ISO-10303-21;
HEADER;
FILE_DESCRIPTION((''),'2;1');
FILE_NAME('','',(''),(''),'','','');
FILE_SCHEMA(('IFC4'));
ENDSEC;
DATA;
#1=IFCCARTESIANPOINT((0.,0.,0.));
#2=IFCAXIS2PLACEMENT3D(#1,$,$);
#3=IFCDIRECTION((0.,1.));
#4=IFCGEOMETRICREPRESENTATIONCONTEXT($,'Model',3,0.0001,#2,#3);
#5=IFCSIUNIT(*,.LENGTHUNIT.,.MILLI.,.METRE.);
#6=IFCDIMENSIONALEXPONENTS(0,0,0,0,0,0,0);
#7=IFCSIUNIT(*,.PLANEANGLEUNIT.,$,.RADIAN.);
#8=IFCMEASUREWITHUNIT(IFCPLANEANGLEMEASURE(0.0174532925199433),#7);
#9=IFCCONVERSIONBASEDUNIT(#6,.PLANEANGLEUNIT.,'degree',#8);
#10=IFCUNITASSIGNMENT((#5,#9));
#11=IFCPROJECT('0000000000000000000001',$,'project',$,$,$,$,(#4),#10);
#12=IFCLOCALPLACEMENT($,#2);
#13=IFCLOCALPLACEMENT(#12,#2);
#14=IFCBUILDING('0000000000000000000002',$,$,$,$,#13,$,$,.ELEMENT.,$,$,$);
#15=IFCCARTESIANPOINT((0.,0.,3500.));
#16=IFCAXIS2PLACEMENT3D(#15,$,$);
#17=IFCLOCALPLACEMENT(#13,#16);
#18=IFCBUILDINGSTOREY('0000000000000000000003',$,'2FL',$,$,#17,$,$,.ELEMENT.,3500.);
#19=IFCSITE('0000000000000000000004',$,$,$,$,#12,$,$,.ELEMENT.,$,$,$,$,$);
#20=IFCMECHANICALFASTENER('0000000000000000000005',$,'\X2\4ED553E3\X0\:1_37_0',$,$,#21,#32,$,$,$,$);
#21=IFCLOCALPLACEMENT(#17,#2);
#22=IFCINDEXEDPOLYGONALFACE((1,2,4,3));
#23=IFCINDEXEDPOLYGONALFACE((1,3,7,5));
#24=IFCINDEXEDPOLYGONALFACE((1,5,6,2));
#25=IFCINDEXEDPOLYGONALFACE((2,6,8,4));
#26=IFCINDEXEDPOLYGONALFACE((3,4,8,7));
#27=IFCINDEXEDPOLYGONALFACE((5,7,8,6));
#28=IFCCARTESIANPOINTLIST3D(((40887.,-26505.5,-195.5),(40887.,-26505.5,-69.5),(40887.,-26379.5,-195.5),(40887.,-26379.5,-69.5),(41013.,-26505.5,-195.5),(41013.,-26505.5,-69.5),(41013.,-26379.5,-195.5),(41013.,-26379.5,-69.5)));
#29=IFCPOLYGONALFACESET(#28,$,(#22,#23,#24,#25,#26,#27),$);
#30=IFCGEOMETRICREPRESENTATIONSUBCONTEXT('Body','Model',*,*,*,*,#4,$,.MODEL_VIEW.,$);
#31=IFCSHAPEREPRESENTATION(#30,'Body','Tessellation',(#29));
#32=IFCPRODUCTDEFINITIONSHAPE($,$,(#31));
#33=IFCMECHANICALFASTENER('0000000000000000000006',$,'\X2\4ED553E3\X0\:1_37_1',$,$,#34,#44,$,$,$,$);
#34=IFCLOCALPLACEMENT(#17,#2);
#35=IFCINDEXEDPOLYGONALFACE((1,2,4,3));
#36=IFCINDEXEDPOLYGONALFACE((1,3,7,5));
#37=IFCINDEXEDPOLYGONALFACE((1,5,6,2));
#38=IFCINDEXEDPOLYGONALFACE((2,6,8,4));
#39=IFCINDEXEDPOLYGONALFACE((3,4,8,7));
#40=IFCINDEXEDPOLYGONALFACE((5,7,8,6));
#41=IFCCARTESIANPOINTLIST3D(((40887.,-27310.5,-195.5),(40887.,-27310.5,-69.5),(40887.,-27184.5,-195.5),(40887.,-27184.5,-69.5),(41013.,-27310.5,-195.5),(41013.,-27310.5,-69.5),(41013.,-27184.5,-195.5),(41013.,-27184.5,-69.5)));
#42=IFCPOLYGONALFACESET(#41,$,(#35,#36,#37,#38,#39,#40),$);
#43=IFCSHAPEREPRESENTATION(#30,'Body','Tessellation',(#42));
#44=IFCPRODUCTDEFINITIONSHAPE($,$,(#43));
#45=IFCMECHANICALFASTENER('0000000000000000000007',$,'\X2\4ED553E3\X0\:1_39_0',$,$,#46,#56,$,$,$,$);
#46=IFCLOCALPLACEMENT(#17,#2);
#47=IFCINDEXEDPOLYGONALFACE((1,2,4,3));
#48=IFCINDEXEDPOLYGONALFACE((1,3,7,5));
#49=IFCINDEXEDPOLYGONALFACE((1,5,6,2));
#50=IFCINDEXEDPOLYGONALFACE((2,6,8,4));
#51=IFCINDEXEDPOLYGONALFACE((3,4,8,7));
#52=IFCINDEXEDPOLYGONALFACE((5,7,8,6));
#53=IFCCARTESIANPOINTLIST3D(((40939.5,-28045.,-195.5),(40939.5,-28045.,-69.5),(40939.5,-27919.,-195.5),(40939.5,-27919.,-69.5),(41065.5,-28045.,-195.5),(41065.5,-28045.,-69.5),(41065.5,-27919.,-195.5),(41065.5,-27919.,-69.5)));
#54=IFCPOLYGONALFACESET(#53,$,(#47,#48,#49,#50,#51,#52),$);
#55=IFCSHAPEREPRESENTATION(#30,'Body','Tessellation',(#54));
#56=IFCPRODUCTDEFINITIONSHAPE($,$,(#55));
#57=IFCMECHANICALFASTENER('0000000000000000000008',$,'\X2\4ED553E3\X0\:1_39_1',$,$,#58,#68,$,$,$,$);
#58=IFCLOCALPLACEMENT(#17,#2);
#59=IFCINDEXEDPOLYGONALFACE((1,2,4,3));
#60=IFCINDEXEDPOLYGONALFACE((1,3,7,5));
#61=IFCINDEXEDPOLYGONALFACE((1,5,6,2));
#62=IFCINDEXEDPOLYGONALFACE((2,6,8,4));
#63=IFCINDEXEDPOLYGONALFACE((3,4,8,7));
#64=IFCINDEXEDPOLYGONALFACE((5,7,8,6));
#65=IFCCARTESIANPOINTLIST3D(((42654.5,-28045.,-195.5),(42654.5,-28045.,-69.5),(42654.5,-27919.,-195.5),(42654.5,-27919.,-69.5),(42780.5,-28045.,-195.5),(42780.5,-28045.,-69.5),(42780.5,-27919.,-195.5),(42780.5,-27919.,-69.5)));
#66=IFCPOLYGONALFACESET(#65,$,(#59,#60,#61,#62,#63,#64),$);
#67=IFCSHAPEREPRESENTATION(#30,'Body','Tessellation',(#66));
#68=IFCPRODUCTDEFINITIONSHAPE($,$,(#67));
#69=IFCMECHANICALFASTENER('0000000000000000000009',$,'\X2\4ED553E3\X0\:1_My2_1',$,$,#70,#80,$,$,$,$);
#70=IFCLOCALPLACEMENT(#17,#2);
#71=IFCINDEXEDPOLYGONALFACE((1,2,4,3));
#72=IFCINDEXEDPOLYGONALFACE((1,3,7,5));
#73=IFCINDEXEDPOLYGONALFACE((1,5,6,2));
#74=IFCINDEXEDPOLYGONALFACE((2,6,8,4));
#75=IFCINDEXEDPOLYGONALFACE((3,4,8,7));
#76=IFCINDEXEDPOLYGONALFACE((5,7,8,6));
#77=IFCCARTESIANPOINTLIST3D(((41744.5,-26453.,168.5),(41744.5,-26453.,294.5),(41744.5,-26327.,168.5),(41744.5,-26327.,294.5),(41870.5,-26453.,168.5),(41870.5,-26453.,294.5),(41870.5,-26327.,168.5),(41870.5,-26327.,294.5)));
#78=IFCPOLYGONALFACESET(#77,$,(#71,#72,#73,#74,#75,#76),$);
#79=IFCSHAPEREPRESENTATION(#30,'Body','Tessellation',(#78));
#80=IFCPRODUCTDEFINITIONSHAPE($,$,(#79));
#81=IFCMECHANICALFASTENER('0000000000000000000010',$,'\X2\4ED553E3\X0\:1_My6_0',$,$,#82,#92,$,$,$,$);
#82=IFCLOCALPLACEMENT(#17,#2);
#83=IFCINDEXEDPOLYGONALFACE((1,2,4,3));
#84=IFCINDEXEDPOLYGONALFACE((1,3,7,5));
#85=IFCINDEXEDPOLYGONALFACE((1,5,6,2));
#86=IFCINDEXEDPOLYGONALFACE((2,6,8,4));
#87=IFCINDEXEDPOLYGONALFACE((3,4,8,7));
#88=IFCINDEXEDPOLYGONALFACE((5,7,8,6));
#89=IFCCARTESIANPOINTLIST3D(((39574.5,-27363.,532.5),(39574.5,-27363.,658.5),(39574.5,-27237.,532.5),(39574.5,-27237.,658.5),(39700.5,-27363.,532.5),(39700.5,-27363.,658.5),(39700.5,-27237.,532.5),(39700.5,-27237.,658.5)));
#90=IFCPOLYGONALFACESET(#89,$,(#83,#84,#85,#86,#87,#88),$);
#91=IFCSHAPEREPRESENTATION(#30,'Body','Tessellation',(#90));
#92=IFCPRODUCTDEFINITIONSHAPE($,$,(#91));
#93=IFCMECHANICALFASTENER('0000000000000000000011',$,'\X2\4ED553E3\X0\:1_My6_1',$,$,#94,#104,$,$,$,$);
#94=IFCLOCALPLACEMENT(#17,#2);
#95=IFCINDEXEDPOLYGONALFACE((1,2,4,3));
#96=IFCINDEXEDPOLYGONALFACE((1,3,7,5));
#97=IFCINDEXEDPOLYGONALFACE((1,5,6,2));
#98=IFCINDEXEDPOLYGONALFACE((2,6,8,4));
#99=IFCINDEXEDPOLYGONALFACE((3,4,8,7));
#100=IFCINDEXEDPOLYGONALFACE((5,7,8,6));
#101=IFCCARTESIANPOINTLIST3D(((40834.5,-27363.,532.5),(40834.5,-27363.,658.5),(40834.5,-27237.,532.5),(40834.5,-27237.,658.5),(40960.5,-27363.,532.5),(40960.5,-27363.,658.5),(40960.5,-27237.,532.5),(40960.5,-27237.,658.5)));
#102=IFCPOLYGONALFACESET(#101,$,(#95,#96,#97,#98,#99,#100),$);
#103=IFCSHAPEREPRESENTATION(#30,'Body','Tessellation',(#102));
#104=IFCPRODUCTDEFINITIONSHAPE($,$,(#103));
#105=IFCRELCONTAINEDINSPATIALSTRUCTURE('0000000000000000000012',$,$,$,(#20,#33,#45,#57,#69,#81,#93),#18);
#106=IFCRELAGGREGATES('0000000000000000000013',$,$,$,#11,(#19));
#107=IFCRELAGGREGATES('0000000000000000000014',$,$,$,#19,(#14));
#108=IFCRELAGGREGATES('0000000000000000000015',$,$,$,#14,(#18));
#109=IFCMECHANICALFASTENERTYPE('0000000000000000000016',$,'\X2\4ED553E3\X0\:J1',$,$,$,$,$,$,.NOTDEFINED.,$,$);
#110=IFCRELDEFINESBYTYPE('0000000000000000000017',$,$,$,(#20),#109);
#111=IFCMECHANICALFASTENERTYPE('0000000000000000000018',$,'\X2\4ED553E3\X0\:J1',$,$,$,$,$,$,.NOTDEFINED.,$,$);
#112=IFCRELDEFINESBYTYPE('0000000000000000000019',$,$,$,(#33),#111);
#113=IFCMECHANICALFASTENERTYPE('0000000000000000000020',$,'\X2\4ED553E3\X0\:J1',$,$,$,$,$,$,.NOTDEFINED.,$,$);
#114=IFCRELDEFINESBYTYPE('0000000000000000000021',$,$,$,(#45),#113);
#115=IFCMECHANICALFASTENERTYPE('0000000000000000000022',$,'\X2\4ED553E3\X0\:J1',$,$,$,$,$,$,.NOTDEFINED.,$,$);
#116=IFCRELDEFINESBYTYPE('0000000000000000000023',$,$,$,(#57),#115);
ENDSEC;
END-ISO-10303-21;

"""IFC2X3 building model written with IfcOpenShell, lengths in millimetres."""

from ifc_helpers import new_model, entity, si_unit, converted_unit, direction, frame, origin, origin_with_axes, origin_2d, place, context, subcontext, project, spatial, rectangle, extrude, type_object, element, save


model = new_model("IFC2X3")

# Units and contexts
model_context = context("Model", 3, precision=0.0001, world=origin(), true_north=direction((0.0, 1.0)))
body_context = subcontext(model_context, "Body", "Model", "MODEL_VIEW")
ifc_project = project(units=[si_unit("LENGTHUNIT", "METRE", prefix="MILLI"), converted_unit("PLANEANGLEUNIT", "degree", entity("IfcPlaneAngleMeasure", 0.0174532925199433), si_unit("PLANEANGLEUNIT", "RADIAN"), dimensions=[0, 0, 0, 0, 0, 0, 0])], contexts=[model_context])

# Site, building, storey
site_placement = place(None, origin())
site = spatial("IfcSite", under=ifc_project, at=site_placement, CompositionType="ELEMENT")
building_placement = place(site_placement, origin())
building = spatial("IfcBuilding", under=site, at=building_placement, CompositionType="ELEMENT")
storey_placement = place(building_placement, frame((0.0, 0.0, 3500.0)))
storey = spatial("IfcBuildingStorey", under=building, at=storey_placement, Name="2FL", CompositionType="ELEMENT", Elevation=3500.0)

# Mechanical fasteners
mechanical_fastener_type_1 = type_object("IfcMechanicalFastenerType", Name="仕口:J1")
mechanical_fastener_1_placement = place(storey_placement, frame((40950.0, -26442.5, -195.5)))
element("IfcMechanicalFastener", 1, at=mechanical_fastener_1_placement, inside=storey, type_object=mechanical_fastener_type_1, Name="仕口:1_37_0", context=body_context, shape_type="SweptSolid", body=[
    extrude(rectangle(XDim=126.0, YDim=126.0, at=origin_2d()), origin_with_axes(), (0.0, 0.0, 1.0), 126.0),
])
mechanical_fastener_type_2 = type_object("IfcMechanicalFastenerType", Name="仕口:J1")
mechanical_fastener_2_placement = place(storey_placement, frame((40950.0, -27247.5, -195.5)))
element("IfcMechanicalFastener", 2, at=mechanical_fastener_2_placement, inside=storey, type_object=mechanical_fastener_type_2, Name="仕口:1_37_1", context=body_context, shape_type="SweptSolid", body=[
    extrude(rectangle(XDim=126.0, YDim=126.0, at=origin_2d()), origin_with_axes(), (0.0, 0.0, 1.0), 126.0),
])
mechanical_fastener_type_3 = type_object("IfcMechanicalFastenerType", Name="仕口:J1")
mechanical_fastener_3_placement = place(storey_placement, frame((41002.5, -27982.0, -195.5)))
element("IfcMechanicalFastener", 3, at=mechanical_fastener_3_placement, inside=storey, type_object=mechanical_fastener_type_3, Name="仕口:1_39_0", context=body_context, shape_type="SweptSolid", body=[
    extrude(rectangle(XDim=126.0, YDim=126.0, at=origin_2d()), origin_with_axes(), (0.0, 0.0, 1.0), 126.0),
])
mechanical_fastener_type_4 = type_object("IfcMechanicalFastenerType", Name="仕口:J1")
mechanical_fastener_4_placement = place(storey_placement, frame((42717.5, -27982.0, -195.5)))
element("IfcMechanicalFastener", 4, at=mechanical_fastener_4_placement, inside=storey, type_object=mechanical_fastener_type_4, Name="仕口:1_39_1", context=body_context, shape_type="SweptSolid", body=[
    extrude(rectangle(XDim=126.0, YDim=126.0, at=origin_2d()), origin_with_axes(), (0.0, 0.0, 1.0), 126.0),
])
for number, where, name in (
    (5, (41807.5, -26390.0, 168.5), "仕口:1_My2_1"),
    (6, (39637.5, -27300.0, 532.5), "仕口:1_My6_0"),
    (7, (40897.5, -27300.0, 532.5), "仕口:1_My6_1"),
):
    element("IfcMechanicalFastener", number, at=place(storey_placement, frame(where)), inside=storey, Name=name, context=body_context, shape_type="SweptSolid", body=[
        extrude(rectangle(XDim=126.0, YDim=126.0, at=origin_2d()), origin_with_axes(), (0.0, 0.0, 1.0), 126.0),
    ])

save(model, "model.ifc")
